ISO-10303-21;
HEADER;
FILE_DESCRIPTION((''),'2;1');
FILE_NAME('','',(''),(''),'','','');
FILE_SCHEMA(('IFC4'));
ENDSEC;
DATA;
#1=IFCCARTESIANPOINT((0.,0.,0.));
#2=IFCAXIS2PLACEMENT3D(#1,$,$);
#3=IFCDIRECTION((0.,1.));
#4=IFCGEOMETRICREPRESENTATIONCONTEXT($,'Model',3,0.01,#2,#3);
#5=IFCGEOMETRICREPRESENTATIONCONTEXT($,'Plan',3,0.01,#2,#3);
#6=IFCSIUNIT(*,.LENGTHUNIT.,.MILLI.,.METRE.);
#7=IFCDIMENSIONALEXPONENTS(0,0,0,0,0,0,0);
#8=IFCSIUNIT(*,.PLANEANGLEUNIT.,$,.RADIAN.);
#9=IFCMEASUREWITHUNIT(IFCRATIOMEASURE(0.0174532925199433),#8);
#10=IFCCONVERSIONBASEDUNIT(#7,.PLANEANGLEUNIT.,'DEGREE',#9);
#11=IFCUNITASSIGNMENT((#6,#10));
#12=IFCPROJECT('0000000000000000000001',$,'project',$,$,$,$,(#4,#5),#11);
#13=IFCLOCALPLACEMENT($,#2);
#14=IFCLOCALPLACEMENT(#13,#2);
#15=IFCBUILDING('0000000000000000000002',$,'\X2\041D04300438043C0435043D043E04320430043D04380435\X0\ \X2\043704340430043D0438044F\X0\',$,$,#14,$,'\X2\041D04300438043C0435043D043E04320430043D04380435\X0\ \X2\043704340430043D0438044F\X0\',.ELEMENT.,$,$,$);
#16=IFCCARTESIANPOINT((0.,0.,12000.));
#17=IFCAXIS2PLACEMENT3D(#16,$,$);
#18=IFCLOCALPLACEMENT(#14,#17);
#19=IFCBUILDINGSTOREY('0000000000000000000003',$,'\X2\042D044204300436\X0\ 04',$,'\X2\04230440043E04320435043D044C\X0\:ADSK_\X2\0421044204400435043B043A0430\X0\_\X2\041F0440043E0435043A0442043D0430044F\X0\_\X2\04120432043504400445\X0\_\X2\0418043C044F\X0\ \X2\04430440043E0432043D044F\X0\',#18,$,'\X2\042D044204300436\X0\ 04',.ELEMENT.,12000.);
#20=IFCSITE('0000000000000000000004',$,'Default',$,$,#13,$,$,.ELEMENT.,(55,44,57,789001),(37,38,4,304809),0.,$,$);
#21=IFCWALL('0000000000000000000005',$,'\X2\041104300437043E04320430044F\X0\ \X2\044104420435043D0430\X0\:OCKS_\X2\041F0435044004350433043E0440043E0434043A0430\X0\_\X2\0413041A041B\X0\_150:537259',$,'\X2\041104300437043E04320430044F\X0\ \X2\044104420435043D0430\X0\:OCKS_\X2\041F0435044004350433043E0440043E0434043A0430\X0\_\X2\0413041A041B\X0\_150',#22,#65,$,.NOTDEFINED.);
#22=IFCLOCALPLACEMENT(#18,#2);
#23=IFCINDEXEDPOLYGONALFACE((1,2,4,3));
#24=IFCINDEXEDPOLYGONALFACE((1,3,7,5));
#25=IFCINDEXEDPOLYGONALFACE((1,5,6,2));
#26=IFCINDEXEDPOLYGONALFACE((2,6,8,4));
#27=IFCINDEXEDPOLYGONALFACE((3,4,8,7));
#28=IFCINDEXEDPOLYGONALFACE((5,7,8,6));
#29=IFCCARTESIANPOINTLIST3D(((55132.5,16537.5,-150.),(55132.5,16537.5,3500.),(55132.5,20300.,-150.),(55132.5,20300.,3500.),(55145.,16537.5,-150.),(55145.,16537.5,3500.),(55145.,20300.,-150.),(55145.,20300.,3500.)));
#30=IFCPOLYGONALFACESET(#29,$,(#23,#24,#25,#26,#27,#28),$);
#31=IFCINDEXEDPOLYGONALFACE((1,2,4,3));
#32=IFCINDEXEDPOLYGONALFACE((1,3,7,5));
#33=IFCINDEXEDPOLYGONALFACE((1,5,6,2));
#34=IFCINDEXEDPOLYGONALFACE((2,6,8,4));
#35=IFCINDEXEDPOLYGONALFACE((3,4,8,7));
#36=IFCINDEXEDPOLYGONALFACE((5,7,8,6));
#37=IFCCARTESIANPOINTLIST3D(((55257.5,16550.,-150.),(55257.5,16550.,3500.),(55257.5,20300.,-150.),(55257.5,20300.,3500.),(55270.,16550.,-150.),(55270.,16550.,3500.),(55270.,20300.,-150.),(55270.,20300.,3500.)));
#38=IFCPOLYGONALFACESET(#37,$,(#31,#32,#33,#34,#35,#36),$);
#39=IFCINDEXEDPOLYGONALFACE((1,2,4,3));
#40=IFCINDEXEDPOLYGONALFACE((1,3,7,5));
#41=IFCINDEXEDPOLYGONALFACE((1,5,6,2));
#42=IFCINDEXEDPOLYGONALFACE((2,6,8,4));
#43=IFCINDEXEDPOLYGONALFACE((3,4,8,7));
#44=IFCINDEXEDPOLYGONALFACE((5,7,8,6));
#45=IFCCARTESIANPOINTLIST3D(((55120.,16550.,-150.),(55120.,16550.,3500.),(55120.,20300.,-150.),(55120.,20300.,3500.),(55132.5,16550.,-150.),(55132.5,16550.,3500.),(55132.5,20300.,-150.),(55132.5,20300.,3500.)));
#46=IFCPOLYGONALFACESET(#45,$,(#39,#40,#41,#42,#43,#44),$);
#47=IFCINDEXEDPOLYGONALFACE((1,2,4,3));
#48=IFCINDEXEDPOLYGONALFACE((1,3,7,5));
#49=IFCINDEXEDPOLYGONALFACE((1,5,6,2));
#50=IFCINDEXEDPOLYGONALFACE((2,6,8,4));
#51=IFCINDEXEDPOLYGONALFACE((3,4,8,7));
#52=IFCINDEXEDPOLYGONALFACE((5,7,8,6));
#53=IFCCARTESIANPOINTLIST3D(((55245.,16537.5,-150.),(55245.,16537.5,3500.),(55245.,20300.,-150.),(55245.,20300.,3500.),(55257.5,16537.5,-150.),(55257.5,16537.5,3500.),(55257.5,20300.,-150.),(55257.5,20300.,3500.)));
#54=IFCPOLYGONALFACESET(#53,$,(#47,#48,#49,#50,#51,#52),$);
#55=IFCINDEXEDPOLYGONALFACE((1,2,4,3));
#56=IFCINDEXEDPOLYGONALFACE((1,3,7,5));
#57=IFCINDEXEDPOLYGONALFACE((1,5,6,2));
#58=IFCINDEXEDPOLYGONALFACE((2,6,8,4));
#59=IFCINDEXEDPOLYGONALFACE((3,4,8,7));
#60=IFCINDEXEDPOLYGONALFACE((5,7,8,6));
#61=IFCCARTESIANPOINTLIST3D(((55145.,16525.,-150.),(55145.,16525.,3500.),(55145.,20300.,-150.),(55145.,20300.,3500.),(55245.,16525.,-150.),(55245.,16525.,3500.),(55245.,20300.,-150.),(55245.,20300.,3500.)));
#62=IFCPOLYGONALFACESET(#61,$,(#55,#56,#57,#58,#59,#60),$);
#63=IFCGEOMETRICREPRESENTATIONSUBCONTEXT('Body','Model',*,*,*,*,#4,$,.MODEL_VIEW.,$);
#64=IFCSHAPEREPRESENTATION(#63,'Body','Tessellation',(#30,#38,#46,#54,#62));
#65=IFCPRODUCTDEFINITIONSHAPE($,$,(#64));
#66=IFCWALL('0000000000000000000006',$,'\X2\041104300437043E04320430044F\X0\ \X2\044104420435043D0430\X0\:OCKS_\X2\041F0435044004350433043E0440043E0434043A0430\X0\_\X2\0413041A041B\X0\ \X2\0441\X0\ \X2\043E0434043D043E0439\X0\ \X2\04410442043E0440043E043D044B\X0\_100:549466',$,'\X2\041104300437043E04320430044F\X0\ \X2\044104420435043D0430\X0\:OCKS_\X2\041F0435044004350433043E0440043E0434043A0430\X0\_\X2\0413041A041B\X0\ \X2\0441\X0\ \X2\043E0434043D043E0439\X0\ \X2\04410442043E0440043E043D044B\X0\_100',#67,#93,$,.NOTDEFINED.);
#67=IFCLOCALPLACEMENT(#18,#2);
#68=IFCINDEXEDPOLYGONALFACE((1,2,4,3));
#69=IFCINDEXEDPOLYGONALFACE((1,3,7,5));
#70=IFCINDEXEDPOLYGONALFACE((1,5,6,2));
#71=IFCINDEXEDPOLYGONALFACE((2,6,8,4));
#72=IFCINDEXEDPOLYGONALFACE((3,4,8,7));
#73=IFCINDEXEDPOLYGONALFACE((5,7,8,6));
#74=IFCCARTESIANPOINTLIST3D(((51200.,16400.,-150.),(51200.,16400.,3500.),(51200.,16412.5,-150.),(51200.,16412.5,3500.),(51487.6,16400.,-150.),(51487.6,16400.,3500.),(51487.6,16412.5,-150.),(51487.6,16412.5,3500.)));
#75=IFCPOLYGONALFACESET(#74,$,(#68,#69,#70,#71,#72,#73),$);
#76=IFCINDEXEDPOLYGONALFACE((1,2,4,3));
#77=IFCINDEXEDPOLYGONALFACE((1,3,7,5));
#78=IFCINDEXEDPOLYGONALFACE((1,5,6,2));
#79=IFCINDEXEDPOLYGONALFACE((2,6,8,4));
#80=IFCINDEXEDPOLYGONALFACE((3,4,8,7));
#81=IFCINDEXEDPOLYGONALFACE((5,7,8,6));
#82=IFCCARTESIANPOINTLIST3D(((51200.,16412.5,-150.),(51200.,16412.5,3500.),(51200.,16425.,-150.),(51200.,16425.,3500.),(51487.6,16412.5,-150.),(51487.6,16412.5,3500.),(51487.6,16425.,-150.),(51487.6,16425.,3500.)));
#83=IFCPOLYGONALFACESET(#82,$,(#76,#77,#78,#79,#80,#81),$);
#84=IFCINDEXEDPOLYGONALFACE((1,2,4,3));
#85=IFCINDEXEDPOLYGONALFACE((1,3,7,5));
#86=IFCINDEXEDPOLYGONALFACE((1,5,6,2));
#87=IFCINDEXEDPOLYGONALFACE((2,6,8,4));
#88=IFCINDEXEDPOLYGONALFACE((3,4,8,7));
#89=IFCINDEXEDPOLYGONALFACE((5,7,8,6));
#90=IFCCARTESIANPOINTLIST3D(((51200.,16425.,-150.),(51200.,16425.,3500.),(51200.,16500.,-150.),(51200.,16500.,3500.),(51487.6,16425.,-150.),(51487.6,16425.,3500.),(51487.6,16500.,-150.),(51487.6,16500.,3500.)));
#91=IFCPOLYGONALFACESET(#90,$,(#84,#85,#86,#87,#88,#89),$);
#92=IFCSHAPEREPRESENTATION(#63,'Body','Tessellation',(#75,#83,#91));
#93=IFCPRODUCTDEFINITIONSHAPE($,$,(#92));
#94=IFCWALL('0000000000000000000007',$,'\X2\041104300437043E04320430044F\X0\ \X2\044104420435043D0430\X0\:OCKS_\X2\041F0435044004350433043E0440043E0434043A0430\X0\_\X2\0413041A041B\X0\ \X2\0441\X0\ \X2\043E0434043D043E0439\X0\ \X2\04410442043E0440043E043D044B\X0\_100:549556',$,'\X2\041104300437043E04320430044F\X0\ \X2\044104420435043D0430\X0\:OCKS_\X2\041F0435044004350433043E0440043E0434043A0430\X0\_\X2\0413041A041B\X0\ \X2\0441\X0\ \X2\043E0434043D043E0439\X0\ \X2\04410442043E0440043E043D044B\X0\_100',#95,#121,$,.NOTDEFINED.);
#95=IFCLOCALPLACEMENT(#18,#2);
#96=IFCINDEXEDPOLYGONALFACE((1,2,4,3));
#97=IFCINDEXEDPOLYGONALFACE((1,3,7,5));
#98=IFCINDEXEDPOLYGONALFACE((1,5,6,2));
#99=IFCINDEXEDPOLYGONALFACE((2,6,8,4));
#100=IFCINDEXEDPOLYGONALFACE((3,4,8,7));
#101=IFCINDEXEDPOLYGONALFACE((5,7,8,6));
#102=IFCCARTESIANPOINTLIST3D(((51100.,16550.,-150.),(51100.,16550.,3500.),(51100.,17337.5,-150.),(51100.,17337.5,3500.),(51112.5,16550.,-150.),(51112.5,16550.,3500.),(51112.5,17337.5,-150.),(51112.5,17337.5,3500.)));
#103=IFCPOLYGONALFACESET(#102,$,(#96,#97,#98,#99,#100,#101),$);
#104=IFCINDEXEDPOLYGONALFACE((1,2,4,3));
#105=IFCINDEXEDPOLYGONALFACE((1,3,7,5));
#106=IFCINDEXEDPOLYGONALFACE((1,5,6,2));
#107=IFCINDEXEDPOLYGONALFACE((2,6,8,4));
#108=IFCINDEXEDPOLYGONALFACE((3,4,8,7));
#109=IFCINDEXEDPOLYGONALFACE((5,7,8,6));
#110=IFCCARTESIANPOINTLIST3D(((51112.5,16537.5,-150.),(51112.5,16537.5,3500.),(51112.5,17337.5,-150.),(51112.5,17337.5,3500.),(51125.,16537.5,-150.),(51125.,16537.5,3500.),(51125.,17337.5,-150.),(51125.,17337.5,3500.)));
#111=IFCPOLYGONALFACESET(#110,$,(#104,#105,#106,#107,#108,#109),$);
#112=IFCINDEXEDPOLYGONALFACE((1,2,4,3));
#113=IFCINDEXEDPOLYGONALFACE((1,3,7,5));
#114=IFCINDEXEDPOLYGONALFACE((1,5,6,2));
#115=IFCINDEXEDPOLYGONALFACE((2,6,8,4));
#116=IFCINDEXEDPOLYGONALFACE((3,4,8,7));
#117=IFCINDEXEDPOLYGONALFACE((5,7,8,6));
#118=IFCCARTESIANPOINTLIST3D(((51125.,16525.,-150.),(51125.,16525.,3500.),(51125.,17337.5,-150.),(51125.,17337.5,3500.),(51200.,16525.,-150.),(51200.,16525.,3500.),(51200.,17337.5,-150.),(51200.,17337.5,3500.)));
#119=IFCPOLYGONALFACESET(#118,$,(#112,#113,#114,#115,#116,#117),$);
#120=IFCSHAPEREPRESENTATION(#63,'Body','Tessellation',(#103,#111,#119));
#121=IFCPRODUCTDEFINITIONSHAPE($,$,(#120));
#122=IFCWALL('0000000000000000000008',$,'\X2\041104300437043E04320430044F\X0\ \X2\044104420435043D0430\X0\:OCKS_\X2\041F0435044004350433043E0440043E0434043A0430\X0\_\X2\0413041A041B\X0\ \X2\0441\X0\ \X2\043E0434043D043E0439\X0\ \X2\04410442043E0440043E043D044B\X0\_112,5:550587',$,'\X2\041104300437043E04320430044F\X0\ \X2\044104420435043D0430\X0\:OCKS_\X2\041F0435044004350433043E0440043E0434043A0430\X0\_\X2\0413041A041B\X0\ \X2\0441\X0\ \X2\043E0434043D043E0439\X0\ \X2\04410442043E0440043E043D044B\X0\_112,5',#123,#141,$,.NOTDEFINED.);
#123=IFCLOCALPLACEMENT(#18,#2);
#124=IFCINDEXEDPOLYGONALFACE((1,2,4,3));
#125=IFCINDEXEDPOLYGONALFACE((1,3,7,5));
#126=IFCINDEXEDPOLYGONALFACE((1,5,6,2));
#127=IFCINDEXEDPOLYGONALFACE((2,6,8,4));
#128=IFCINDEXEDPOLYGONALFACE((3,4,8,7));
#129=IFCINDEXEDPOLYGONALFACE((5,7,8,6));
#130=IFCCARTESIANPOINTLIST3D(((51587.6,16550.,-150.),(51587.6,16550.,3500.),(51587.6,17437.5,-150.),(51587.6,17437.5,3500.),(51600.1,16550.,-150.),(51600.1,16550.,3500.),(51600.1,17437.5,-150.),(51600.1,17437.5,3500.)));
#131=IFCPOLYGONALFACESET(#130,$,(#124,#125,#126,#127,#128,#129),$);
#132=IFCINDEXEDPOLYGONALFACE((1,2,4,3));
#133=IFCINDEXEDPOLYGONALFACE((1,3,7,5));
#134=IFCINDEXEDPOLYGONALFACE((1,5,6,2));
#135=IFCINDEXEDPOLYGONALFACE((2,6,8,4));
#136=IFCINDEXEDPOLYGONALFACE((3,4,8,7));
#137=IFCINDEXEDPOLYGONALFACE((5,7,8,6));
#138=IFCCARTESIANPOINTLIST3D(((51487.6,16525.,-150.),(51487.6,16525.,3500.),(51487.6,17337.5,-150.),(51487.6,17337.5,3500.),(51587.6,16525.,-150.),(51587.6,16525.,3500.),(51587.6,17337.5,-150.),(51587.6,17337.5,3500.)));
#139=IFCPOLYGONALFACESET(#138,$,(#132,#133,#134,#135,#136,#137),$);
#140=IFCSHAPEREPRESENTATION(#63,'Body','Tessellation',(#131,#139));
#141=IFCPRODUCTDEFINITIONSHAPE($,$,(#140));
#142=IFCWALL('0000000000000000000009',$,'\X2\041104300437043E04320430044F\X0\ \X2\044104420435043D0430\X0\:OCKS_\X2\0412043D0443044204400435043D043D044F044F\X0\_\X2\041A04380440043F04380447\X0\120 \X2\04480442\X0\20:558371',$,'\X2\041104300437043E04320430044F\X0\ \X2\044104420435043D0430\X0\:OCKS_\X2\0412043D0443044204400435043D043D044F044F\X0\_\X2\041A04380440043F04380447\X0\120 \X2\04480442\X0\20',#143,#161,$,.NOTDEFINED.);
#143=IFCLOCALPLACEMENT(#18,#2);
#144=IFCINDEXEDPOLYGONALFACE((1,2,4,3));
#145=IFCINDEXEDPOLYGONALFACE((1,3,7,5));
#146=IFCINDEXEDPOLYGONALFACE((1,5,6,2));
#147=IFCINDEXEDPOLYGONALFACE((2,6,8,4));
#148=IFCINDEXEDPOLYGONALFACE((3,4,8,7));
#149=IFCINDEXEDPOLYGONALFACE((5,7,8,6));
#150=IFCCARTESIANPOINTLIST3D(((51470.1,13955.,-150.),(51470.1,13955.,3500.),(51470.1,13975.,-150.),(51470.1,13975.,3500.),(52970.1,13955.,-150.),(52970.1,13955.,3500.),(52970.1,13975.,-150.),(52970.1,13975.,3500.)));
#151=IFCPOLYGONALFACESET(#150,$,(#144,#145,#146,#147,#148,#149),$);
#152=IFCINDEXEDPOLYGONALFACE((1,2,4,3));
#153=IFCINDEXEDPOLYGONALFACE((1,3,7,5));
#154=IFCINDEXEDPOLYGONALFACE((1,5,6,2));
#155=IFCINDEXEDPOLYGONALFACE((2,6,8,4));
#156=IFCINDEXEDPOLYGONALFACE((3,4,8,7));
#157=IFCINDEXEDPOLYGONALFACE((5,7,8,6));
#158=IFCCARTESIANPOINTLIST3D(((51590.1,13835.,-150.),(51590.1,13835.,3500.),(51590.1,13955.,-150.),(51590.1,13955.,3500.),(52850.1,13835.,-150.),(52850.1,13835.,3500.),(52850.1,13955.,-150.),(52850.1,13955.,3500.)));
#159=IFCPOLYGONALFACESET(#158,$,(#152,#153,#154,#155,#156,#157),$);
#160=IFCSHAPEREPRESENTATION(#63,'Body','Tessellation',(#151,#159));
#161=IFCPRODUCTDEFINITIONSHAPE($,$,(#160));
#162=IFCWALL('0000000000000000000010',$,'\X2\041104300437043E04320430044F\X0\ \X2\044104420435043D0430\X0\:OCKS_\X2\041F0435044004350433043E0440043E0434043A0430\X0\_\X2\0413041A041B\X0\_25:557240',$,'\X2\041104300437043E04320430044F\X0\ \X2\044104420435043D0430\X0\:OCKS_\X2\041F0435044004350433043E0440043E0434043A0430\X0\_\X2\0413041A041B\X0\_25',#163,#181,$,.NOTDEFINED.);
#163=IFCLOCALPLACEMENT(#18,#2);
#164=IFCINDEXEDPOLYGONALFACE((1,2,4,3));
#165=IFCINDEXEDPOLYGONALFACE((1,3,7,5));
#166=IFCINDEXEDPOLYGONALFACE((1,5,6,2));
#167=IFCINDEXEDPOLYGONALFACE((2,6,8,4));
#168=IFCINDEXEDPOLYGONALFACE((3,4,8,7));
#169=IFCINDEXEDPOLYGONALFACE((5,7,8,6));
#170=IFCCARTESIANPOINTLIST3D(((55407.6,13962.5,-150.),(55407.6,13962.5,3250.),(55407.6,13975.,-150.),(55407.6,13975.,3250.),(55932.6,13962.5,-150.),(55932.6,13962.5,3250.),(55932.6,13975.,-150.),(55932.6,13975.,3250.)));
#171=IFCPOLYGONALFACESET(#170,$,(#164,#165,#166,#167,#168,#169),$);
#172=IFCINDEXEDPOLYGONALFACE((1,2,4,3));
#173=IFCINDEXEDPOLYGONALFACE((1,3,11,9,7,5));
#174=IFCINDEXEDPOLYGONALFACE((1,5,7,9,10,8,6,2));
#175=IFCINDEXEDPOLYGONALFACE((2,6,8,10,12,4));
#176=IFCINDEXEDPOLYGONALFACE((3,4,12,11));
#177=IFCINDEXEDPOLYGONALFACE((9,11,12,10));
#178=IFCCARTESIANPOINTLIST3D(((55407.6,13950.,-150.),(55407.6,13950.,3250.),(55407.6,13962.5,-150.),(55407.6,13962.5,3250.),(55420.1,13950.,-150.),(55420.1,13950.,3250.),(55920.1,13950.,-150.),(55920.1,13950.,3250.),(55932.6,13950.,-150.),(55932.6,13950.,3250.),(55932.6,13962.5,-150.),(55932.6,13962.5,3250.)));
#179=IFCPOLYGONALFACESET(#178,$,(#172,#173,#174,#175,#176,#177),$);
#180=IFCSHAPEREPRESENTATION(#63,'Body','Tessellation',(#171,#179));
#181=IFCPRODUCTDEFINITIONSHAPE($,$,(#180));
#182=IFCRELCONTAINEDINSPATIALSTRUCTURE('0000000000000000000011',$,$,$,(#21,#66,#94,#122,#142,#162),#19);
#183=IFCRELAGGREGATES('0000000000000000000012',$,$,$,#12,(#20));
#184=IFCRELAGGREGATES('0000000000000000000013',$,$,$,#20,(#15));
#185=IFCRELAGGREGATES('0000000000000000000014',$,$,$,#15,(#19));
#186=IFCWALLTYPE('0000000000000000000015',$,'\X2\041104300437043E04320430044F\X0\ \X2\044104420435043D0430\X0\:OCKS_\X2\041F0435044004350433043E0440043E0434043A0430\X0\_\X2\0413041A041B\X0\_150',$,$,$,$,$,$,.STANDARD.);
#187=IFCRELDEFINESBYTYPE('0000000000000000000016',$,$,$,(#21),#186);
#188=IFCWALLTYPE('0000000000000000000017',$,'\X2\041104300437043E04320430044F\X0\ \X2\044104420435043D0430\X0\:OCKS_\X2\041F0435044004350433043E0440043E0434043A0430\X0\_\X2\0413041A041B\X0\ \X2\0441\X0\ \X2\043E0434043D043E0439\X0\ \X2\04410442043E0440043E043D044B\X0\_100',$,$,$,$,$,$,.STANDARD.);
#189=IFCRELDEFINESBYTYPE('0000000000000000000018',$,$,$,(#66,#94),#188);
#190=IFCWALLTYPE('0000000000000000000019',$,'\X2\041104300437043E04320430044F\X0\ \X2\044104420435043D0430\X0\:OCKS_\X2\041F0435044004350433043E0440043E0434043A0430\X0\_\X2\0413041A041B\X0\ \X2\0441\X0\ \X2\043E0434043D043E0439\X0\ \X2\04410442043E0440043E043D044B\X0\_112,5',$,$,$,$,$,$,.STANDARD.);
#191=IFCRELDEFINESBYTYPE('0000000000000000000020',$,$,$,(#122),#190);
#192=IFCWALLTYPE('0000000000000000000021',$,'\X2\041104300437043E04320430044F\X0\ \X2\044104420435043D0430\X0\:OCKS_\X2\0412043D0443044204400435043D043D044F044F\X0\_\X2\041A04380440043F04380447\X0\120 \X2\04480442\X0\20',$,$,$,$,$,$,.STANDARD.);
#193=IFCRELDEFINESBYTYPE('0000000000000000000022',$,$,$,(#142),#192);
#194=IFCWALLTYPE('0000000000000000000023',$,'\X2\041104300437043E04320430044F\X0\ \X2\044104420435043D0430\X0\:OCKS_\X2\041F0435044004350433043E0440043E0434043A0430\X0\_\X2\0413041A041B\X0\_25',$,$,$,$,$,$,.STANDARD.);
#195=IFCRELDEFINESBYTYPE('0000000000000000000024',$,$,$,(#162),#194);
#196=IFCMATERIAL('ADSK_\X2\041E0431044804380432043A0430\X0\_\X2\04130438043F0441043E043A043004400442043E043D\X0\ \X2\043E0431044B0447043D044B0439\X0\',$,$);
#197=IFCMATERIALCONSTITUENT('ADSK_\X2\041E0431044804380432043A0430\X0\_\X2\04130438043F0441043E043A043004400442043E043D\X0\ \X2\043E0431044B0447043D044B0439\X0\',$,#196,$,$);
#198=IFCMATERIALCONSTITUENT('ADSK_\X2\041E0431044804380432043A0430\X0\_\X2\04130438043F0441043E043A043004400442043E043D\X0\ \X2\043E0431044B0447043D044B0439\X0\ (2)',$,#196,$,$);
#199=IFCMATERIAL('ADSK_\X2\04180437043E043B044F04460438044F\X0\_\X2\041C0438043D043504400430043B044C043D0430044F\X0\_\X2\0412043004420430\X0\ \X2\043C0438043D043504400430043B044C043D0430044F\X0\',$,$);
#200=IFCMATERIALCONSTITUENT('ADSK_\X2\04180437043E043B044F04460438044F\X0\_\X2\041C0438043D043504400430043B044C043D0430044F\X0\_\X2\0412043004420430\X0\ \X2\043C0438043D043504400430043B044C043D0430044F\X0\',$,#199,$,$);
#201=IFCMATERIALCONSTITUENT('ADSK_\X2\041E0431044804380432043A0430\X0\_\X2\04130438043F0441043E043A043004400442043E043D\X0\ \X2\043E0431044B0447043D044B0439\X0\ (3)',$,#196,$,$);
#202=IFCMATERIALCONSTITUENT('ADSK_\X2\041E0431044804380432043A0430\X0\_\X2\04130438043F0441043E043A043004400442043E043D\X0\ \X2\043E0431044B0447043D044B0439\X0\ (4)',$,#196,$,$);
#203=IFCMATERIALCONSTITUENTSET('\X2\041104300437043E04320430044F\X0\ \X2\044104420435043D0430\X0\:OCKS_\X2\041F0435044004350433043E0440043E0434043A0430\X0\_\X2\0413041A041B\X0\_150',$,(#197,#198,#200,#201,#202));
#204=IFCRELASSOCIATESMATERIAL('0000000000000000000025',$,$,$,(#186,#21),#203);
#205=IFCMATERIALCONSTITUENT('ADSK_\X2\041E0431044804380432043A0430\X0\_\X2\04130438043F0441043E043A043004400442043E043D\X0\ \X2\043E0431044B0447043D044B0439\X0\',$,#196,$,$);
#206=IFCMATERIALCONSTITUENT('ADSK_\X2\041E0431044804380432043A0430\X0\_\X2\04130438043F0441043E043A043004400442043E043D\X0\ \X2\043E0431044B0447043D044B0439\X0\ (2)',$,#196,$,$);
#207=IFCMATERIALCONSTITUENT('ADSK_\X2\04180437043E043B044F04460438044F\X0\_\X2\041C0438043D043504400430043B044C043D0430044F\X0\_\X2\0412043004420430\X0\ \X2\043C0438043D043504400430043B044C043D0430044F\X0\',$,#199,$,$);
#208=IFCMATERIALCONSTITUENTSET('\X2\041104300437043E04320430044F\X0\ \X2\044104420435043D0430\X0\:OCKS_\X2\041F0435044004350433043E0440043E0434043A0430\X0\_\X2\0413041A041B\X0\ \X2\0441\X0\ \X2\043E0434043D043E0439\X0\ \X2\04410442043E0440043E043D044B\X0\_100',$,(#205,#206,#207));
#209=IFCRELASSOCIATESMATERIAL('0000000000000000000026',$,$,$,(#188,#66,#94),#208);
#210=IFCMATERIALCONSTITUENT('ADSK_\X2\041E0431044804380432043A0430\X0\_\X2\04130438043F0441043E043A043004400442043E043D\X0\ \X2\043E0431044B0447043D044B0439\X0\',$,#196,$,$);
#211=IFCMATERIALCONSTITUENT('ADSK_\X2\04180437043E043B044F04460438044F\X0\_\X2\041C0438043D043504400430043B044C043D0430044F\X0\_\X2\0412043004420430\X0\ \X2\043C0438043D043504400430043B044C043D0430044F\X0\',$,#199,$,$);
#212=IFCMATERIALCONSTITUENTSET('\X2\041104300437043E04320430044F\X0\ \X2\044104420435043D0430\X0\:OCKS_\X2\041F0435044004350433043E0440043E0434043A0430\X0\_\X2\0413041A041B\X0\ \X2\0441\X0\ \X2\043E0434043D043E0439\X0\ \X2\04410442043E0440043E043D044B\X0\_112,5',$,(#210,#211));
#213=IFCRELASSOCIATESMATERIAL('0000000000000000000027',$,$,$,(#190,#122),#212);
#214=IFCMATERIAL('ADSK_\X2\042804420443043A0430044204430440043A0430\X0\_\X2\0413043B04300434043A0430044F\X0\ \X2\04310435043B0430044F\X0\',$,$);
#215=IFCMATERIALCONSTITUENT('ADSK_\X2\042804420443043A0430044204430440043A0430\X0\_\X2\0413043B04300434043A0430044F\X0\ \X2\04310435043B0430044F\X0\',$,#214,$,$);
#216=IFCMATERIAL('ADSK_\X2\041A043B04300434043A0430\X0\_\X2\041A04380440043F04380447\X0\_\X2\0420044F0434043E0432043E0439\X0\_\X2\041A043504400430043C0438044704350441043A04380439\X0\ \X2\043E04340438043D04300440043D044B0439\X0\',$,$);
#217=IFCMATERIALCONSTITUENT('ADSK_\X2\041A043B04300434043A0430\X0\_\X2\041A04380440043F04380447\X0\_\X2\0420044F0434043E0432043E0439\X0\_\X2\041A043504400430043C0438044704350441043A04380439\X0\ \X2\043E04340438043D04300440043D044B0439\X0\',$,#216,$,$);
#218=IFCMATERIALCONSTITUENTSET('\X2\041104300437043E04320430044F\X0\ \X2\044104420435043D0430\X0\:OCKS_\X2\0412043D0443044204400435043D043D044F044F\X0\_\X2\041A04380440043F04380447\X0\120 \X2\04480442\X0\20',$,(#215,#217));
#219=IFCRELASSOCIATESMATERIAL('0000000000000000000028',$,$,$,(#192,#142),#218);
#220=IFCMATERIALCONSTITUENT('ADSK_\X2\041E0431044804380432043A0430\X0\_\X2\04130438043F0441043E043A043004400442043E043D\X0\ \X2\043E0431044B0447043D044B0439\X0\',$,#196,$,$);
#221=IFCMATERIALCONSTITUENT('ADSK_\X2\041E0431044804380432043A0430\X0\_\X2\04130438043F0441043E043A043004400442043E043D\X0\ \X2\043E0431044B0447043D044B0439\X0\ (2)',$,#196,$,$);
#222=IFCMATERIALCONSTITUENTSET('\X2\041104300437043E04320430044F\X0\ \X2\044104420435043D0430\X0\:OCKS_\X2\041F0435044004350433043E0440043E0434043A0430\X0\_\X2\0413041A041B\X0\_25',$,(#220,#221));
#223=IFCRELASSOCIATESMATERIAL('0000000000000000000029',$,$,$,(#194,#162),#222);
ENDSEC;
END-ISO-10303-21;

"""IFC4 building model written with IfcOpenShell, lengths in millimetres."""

from ifc_helpers import new_model, entity, si_unit, converted_unit, direction, frame, origin, place, context, subcontext, project, spatial, indexed_curve, outline, extrude, material, constituent, constituent_set, type_object, element, save


model = new_model("IFC4")

# Units and contexts
model_context = context("Model", 3, precision=0.01, world=origin(), true_north=direction((0.0, 1.0)))
plan_context = context("Plan", 3, precision=0.01, world=origin(), true_north=direction((0.0, 1.0)))
body_context = subcontext(model_context, "Body", "Model", "MODEL_VIEW")
ifc_project = project(units=[si_unit("LENGTHUNIT", "METRE", prefix="MILLI"), converted_unit("PLANEANGLEUNIT", "DEGREE", entity("IfcRatioMeasure", 0.0174532925199433), si_unit("PLANEANGLEUNIT", "RADIAN"), dimensions=[0, 0, 0, 0, 0, 0, 0])], contexts=[model_context, plan_context])

# Site, building, storey
site_placement = place(None, frame((0.0, 0.0, 0.0)))
site = spatial("IfcSite", under=ifc_project, at=site_placement, Name="Default", CompositionType="ELEMENT", RefLatitude=(55, 44, 57, 789001), RefLongitude=(37, 38, 4, 304809), RefElevation=0.0)
building_placement = place(site_placement, origin())
building = spatial("IfcBuilding", under=site, at=building_placement, Name="Наименование здания", LongName="Наименование здания", CompositionType="ELEMENT")
storey_placement = place(building_placement, frame((0.0, 0.0, 12000.0)))
storey = spatial("IfcBuildingStorey", under=building, at=storey_placement, Name="Этаж 04", ObjectType="Уровень:ADSK_Стрелка_Проектная_Вверх_Имя уровня", LongName="Этаж 04", CompositionType="ELEMENT", Elevation=12000.0)

# Wall
ifc_material_1 = material(Name="ADSK_Обшивка_Гипсокартон обычный")
ifc_constituent_1 = constituent(ifc_material_1, Name="ADSK_Обшивка_Гипсокартон обычный")
ifc_constituent_2 = constituent(ifc_material_1, Name="ADSK_Обшивка_Гипсокартон обычный (2)")
ifc_material_2 = material(Name="ADSK_Изоляция_Минеральная_Вата минеральная")
ifc_constituent_3 = constituent(ifc_material_2, Name="ADSK_Изоляция_Минеральная_Вата минеральная")
ifc_constituent_4 = constituent(ifc_material_1, Name="ADSK_Обшивка_Гипсокартон обычный (3)")
ifc_constituent_5 = constituent(ifc_material_1, Name="ADSK_Обшивка_Гипсокартон обычный (4)")
ifc_constituent_set_1 = constituent_set(constituents=[ifc_constituent_1, ifc_constituent_2, ifc_constituent_3, ifc_constituent_4, ifc_constituent_5], Name="Базовая стена:OCKS_Перегородка_ГКЛ_150")
wall_type_1 = type_object("IfcWallType", Name="Базовая стена:OCKS_Перегородка_ГКЛ_150", PredefinedType="STANDARD", material=ifc_constituent_set_1)
wall_1_placement = place(storey_placement, frame((55195.0, 20300.0, -150.0), z_axis=(0.0, 0.0, 1.0), x_axis=(0.0, -1.0, 0.0)))
element("IfcWall", 1, at=wall_1_placement, inside=storey, type_object=wall_type_1, material=ifc_constituent_set_1, Name="Базовая стена:OCKS_Перегородка_ГКЛ_150:537259", ObjectType="Базовая стена:OCKS_Перегородка_ГКЛ_150", PredefinedType="NOTDEFINED", context=body_context, shape_type="SweptSolid", body=[
    extrude(outline(indexed_curve([(-1881.3, -6.3), (1881.3, -6.3), (1881.3, 6.2), (-1881.3, 6.2), (-1881.3, -6.3)], self_intersect=False)), frame((1881.3, -56.2, 0.0)), (0.0, 0.0, 1.0), 3650.0),
    extrude(outline(indexed_curve([(-6.2, -1875.0), (6.3, -1875.0), (6.3, 1875.0), (-6.2, 1875.0), (-6.2, -1875.0)], self_intersect=False)), frame((1875.0, 68.8, 0.0), z_axis=(0.0, 0.0, 1.0), x_axis=(0.0, -1.0, 0.0)), (0.0, 0.0, 1.0), 3650.0),
    extrude(outline(indexed_curve([(-6.3, -1875.0), (6.2, -1875.0), (6.3, 1875.0), (-6.2, 1875.0), (-6.3, -1875.0)], self_intersect=False)), frame((1875.0, -68.8, 0.0), z_axis=(0.0, 0.0, 1.0), x_axis=(0.0, 1.0, 0.0)), (0.0, 0.0, 1.0), 3650.0),
    extrude(outline(indexed_curve([(-1881.3, -6.3), (1881.3, -6.3), (1881.3, 6.2), (-1881.3, 6.2), (-1881.3, -6.3)], self_intersect=False)), frame((1881.3, 56.3, 0.0)), (0.0, 0.0, 1.0), 3650.0),
    extrude(outline(indexed_curve([(-1887.5, -50.0), (1887.5, -50.0), (1887.5, 50.0), (-1887.5, 50.0), (-1887.5, -50.0)], self_intersect=False)), frame((1887.5, 0.0, 0.0)), (0.0, 0.0, 1.0), 3650.0),
])

# Walls
ifc_constituent_6 = constituent(ifc_material_1, Name="ADSK_Обшивка_Гипсокартон обычный")
ifc_constituent_7 = constituent(ifc_material_1, Name="ADSK_Обшивка_Гипсокартон обычный (2)")
ifc_constituent_8 = constituent(ifc_material_2, Name="ADSK_Изоляция_Минеральная_Вата минеральная")
ifc_constituent_set_2 = constituent_set(constituents=[ifc_constituent_6, ifc_constituent_7, ifc_constituent_8], Name="Базовая стена:OCKS_Перегородка_ГКЛ с одной стороны_100")
wall_type_2 = type_object("IfcWallType", Name="Базовая стена:OCKS_Перегородка_ГКЛ с одной стороны_100", PredefinedType="STANDARD", material=ifc_constituent_set_2)
wall_2_placement = place(storey_placement, frame((51200.0, 16450.0, -150.0)))
element("IfcWall", 2, at=wall_2_placement, inside=storey, type_object=wall_type_2, material=ifc_constituent_set_2, Name="Базовая стена:OCKS_Перегородка_ГКЛ с одной стороны_100:549466", ObjectType="Базовая стена:OCKS_Перегородка_ГКЛ с одной стороны_100", PredefinedType="NOTDEFINED", context=body_context, shape_type="SweptSolid", body=[
    extrude(outline(indexed_curve([(-6.2, -143.8), (6.3, -143.8), (6.3, 143.8), (-6.2, 143.8), (-6.2, -143.8)], self_intersect=False)), frame((143.8, -43.8, 0.0), z_axis=(0.0, 0.0, 1.0), x_axis=(0.0, 1.0, 0.0)), (0.0, 0.0, 1.0), 3650.0),
    extrude(outline(indexed_curve([(-143.8, -6.3), (143.8, -6.3), (143.8, 6.2), (-143.8, 6.2), (-143.8, -6.3)], self_intersect=False)), frame((143.8, -31.2, 0.0)), (0.0, 0.0, 1.0), 3650.0),
    extrude(outline(indexed_curve([(-37.5, -143.8), (37.5, -143.8), (37.5, 143.8), (-37.5, 143.8), (-37.5, -143.8)], self_intersect=False)), frame((143.8, 12.5, 0.0), z_axis=(0.0, 0.0, 1.0), x_axis=(0.0, -1.0, 0.0)), (0.0, 0.0, 1.0), 3650.0),
])
wall_3_placement = place(storey_placement, frame((51150.0, 16550.0, -150.0), z_axis=(0.0, 0.0, 1.0), x_axis=(0.0, 1.0, 0.0)))
element("IfcWall", 3, at=wall_3_placement, inside=storey, type_object=wall_type_2, material=ifc_constituent_set_2, Name="Базовая стена:OCKS_Перегородка_ГКЛ с одной стороны_100:549556", ObjectType="Базовая стена:OCKS_Перегородка_ГКЛ с одной стороны_100", PredefinedType="NOTDEFINED", context=body_context, shape_type="SweptSolid", body=[
    extrude(outline(indexed_curve([(-6.3, -393.8), (6.2, -393.8), (6.2, 393.8), (-6.3, 393.8), (-6.3, -393.8)], self_intersect=False)), frame((393.8, 43.7, 0.0), z_axis=(0.0, 0.0, 1.0), x_axis=(0.0, -1.0, 0.0)), (0.0, 0.0, 1.0), 3650.0),
    extrude(outline(indexed_curve([(-400.0, -6.3), (400.0, -6.3), (400.0, 6.2), (-400.0, 6.2), (-400.0, -6.3)], self_intersect=False)), frame((387.5, 31.3, 0.0)), (0.0, 0.0, 1.0), 3650.0),
    extrude(outline(indexed_curve([(-37.5, -406.3), (37.5, -406.3), (37.5, 406.3), (-37.5, 406.3), (-37.5, -406.3)], self_intersect=False)), frame((381.3, -12.5, 0.0), z_axis=(0.0, 0.0, 1.0), x_axis=(0.0, 1.0, 0.0)), (0.0, 0.0, 1.0), 3650.0),
])
ifc_constituent_9 = constituent(ifc_material_1, Name="ADSK_Обшивка_Гипсокартон обычный")
ifc_constituent_10 = constituent(ifc_material_2, Name="ADSK_Изоляция_Минеральная_Вата минеральная")
ifc_constituent_set_3 = constituent_set(constituents=[ifc_constituent_9, ifc_constituent_10], Name="Базовая стена:OCKS_Перегородка_ГКЛ с одной стороны_112,5")
wall_type_3 = type_object("IfcWallType", Name="Базовая стена:OCKS_Перегородка_ГКЛ с одной стороны_112,5", PredefinedType="STANDARD", material=ifc_constituent_set_3)
wall_4_placement = place(storey_placement, frame((51543.9, 17337.5, -150.0), z_axis=(0.0, 0.0, 1.0), x_axis=(0.0, -1.0, 0.0)))
element("IfcWall", 4, at=wall_4_placement, inside=storey, type_object=wall_type_3, material=ifc_constituent_set_3, Name="Базовая стена:OCKS_Перегородка_ГКЛ с одной стороны_112,5:550587", ObjectType="Базовая стена:OCKS_Перегородка_ГКЛ с одной стороны_112,5", PredefinedType="NOTDEFINED", context=body_context, shape_type="SweptSolid", body=[
    extrude(outline(indexed_curve([(-6.2, -443.8), (6.3, -443.8), (6.3, 443.8), (-6.2, 443.8), (-6.2, -443.8)], self_intersect=False)), frame((343.8, 50.0, 0.0), z_axis=(0.0, 0.0, 1.0), x_axis=(0.0, -1.0, 0.0)), (0.0, 0.0, 1.0), 3650.0),
    extrude(outline(indexed_curve([(-50.0, -406.3), (50.0, -406.3), (50.0, 406.3), (-50.0, 406.3), (-50.0, -406.3)], self_intersect=False)), frame((406.3, -6.3, 0.0), z_axis=(0.0, 0.0, 1.0), x_axis=(0.0, 1.0, 0.0)), (0.0, 0.0, 1.0), 3650.0),
])
ifc_material_3 = material(Name="ADSK_Штукатурка_Гладкая белая")
ifc_constituent_11 = constituent(ifc_material_3, Name="ADSK_Штукатурка_Гладкая белая")
ifc_material_4 = material(Name="ADSK_Кладка_Кирпич_Рядовой_Керамический одинарный")
ifc_constituent_12 = constituent(ifc_material_4, Name="ADSK_Кладка_Кирпич_Рядовой_Керамический одинарный")
ifc_constituent_set_4 = constituent_set(constituents=[ifc_constituent_11, ifc_constituent_12], Name="Базовая стена:OCKS_Внутренняя_Кирпич120 шт20")
wall_type_4 = type_object("IfcWallType", Name="Базовая стена:OCKS_Внутренняя_Кирпич120 шт20", PredefinedType="STANDARD", material=ifc_constituent_set_4)
wall_5_placement = place(storey_placement, frame((51590.1, 13905.0, -150.0)))
element("IfcWall", 5, at=wall_5_placement, inside=storey, type_object=wall_type_4, material=ifc_constituent_set_4, Name="Базовая стена:OCKS_Внутренняя_Кирпич120 шт20:558371", ObjectType="Базовая стена:OCKS_Внутренняя_Кирпич120 шт20", PredefinedType="NOTDEFINED", context=body_context, shape_type="SweptSolid", body=[
    extrude(outline(indexed_curve([(-10.0, -750.0), (10.0, -750.0), (10.0, 750.0), (-10.0, 750.0), (-10.0, -750.0)], self_intersect=False)), frame((630.0, 60.0, 0.0), z_axis=(0.0, 0.0, 1.0), x_axis=(0.0, -1.0, 0.0)), (0.0, 0.0, 1.0), 3650.0),
    extrude(outline(indexed_curve([(-60.0, -630.0), (60.0, -630.0), (60.0, 630.0), (-60.0, 630.0), (-60.0, -630.0)], self_intersect=False)), frame((630.0, -10.0, 0.0), z_axis=(0.0, 0.0, 1.0), x_axis=(0.0, 1.0, 0.0)), (0.0, 0.0, 1.0), 3650.0),
])
ifc_constituent_13 = constituent(ifc_material_1, Name="ADSK_Обшивка_Гипсокартон обычный")
ifc_constituent_14 = constituent(ifc_material_1, Name="ADSK_Обшивка_Гипсокартон обычный (2)")
ifc_constituent_set_5 = constituent_set(constituents=[ifc_constituent_13, ifc_constituent_14], Name="Базовая стена:OCKS_Перегородка_ГКЛ_25")
wall_type_5 = type_object("IfcWallType", Name="Базовая стена:OCKS_Перегородка_ГКЛ_25", PredefinedType="STANDARD", material=ifc_constituent_set_5)
wall_6_placement = place(storey_placement, frame((55932.6, 13962.5, -150.0), z_axis=(0.0, 0.0, 1.0), x_axis=(-1.0, 0.0, 0.0)))
element("IfcWall", 6, at=wall_6_placement, inside=storey, type_object=wall_type_5, material=ifc_constituent_set_5, Name="Базовая стена:OCKS_Перегородка_ГКЛ_25:557240", ObjectType="Базовая стена:OCKS_Перегородка_ГКЛ_25", PredefinedType="NOTDEFINED", context=body_context, shape_type="SweptSolid", body=[
    extrude(outline(indexed_curve([(-6.3, -262.5), (6.3, -262.5), (6.3, 262.5), (-6.2, 262.5), (-6.3, -262.5)], self_intersect=False)), frame((262.5, -6.3, 0.0), z_axis=(0.0, 0.0, 1.0), x_axis=(0.0, 1.0, 0.0)), (0.0, 0.0, 1.0), 3400.0),
    extrude(outline(indexed_curve([(-250.0, -4.2), (250.0, -4.2), (262.5, -4.2), (262.5, 8.3), (-262.5, 8.3), (-262.5, -4.2), (-250.0, -4.2)], self_intersect=False)), frame((262.5, 8.3, 0.0), z_axis=(0.0, 0.0, 1.0), x_axis=(-1.0, 0.0, 0.0)), (0.0, 0.0, 1.0), 3400.0),
])

save(model, "model.ifc")
